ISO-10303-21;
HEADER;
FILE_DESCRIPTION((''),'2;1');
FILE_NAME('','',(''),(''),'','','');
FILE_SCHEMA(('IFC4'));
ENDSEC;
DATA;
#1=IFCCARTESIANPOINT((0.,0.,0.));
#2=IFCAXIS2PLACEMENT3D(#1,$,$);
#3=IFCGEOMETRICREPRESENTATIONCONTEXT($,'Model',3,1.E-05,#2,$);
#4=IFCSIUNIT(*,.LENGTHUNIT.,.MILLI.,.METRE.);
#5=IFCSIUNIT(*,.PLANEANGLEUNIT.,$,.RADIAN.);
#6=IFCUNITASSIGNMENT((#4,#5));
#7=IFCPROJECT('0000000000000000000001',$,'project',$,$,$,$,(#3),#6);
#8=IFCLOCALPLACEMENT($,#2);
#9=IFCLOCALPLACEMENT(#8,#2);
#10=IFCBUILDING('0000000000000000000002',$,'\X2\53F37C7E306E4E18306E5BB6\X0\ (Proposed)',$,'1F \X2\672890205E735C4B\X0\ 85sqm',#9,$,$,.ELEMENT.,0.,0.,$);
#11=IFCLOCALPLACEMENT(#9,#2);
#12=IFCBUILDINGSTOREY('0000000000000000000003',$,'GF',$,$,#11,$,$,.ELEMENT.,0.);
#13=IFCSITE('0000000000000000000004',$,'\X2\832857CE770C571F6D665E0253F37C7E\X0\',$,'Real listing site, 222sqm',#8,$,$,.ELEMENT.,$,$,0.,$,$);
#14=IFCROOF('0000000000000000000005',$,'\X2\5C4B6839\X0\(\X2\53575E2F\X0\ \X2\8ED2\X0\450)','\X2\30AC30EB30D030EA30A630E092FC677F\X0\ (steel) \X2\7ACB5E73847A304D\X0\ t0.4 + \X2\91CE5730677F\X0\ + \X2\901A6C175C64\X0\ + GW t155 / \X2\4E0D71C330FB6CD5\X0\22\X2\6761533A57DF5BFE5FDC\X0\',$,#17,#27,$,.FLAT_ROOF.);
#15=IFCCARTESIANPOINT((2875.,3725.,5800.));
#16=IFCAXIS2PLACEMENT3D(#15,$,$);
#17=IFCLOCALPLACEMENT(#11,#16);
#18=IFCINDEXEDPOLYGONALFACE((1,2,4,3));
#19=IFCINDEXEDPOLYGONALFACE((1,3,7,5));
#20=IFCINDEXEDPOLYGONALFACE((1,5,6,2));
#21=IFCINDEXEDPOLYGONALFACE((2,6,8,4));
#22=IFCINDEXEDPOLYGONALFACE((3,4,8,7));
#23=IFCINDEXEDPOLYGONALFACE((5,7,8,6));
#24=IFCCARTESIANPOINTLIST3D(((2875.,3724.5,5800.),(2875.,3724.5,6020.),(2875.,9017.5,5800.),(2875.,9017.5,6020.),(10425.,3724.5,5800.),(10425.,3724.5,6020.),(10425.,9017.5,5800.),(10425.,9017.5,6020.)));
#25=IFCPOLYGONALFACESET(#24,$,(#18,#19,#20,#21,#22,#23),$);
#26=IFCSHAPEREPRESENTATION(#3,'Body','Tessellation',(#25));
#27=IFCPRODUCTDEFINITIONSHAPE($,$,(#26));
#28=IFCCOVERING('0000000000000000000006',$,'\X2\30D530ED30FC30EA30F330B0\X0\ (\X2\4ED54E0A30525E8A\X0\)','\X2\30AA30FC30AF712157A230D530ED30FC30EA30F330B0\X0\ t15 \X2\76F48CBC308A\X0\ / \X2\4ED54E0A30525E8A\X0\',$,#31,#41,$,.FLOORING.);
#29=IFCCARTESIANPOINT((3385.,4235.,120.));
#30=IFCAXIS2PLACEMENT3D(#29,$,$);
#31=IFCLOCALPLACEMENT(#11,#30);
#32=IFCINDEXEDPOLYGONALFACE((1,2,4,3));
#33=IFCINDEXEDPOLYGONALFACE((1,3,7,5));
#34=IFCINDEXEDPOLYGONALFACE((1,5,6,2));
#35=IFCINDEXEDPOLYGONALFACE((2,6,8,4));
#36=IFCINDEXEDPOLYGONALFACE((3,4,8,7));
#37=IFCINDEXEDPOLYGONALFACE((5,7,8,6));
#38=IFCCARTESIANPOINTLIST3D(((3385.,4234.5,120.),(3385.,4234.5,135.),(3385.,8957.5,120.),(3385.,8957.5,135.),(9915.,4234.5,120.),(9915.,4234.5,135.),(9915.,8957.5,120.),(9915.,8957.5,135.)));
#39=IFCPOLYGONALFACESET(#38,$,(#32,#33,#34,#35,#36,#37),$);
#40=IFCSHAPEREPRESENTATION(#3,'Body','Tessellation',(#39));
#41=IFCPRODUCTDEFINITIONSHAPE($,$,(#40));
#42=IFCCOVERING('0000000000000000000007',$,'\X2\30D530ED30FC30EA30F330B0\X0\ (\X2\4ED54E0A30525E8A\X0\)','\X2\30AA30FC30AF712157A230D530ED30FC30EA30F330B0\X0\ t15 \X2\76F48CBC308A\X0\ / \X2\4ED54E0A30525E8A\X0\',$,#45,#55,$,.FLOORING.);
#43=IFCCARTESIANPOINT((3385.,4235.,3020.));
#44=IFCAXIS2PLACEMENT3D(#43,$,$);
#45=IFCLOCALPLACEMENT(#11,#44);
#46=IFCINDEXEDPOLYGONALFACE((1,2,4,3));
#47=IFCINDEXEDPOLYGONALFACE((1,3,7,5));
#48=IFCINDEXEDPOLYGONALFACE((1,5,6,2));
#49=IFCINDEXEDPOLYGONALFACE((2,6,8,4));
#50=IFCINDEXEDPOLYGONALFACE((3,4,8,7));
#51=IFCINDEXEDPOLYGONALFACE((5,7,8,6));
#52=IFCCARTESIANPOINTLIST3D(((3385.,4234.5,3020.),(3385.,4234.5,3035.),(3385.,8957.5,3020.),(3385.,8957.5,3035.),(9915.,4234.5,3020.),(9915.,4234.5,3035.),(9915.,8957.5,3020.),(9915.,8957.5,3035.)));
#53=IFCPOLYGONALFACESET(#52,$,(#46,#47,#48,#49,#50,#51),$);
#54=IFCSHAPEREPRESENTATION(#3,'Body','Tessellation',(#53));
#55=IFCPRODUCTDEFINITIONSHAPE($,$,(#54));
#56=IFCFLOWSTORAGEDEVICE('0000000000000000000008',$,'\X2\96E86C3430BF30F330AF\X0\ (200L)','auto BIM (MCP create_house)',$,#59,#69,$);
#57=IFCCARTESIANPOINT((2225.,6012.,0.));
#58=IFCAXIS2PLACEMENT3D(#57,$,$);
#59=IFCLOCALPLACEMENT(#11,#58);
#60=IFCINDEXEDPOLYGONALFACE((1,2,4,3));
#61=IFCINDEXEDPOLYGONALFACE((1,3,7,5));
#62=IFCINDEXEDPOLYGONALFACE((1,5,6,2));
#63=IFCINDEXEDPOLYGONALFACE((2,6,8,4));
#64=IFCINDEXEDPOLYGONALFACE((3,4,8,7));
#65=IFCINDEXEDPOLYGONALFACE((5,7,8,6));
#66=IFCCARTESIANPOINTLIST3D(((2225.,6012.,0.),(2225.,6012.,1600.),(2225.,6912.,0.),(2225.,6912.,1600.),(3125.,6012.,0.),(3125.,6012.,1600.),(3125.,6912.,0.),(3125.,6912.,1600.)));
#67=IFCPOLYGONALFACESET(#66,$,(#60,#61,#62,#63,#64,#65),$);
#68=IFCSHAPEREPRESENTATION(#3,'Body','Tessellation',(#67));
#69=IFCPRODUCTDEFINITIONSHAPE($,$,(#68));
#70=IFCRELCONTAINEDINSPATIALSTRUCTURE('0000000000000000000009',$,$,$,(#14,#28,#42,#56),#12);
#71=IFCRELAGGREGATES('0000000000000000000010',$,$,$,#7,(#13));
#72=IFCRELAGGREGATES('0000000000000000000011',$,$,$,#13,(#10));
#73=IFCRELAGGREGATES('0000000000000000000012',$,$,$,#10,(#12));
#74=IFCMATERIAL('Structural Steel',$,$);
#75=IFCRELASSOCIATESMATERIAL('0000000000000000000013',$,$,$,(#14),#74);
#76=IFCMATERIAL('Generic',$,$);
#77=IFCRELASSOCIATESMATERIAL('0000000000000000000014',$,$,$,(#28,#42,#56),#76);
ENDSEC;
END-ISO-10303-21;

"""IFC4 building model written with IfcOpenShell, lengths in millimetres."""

from ifc_helpers import new_model, si_unit, frame, frame_2d, origin, place, context, project, spatial, rectangle, extrude, material, element, save


model = new_model("IFC4")

# Units and contexts
model_context = context("Model", 3, precision=1e-05, world=origin())
ifc_project = project(units=[si_unit("LENGTHUNIT", "METRE", prefix="MILLI"), si_unit("PLANEANGLEUNIT", "RADIAN")], contexts=[model_context])

# Site, building, storey
site_placement = place(None, origin())
site = spatial("IfcSite", under=ifc_project, at=site_placement, Name="茨城県土浦市右籾", ObjectType="Real listing site, 222sqm", CompositionType="ELEMENT", RefElevation=0.0)
building_placement = place(site_placement, origin())
building = spatial("IfcBuilding", under=site, at=building_placement, Name="右籾の丘の家 (Proposed)", ObjectType="1F 木造平屋 85sqm", CompositionType="ELEMENT", ElevationOfRefHeight=0.0, ElevationOfTerrain=0.0)
storey_placement = place(building_placement, origin())
storey = spatial("IfcBuildingStorey", under=building, at=storey_placement, Name="GF", CompositionType="ELEMENT", Elevation=0.0)

# Shared definitions
ifc_material_1 = material(Name="Generic")

# Roof
ifc_material_2 = material(Name="Structural Steel")
for number, where, name in (
    (1, (2875.0, 3725.0, 5800.0), "屋根(南帯 軒450)"),
):
    element("IfcRoof", number, at=place(storey_placement, frame(where)), inside=storey, material=ifc_material_2, Name=name, Description="ガルバリウム鋼板 (steel) 立平葺き t0.4 + 野地板 + 通気層 + GW t155 / 不燃・法22条区域対応", PredefinedType="FLAT_ROOF", context=model_context, shape_type="SweptSolid", body=[
        extrude(rectangle(XDim=7550.0, YDim=5293.0, at=frame_2d((3775.0, 2646.0))), frame((2875.0, 3725.0, 5800.0)), (0.0, 0.0, 1.0), 220.0),
    ])

# Coverings
covering_1_placement = place(storey_placement, frame((3385.0, 4235.0, 120.0)))
element("IfcCovering", 2, at=covering_1_placement, inside=storey, material=ifc_material_1, Name="フローリング (仕上げ床)", Description="オーク無垢フローリング t15 直貼り / 仕上げ床", PredefinedType="FLOORING", context=model_context, shape_type="SweptSolid", body=[
    extrude(rectangle(XDim=6530.0, YDim=4723.0, at=frame_2d((3265.0, 2361.0))), frame((3385.0, 4235.0, 120.0)), (0.0, 0.0, 1.0), 15.0),
])
covering_2_placement = place(storey_placement, frame((3385.0, 4235.0, 3020.0)))
element("IfcCovering", 3, at=covering_2_placement, inside=storey, material=ifc_material_1, Name="フローリング (仕上げ床)", Description="オーク無垢フローリング t15 直貼り / 仕上げ床", PredefinedType="FLOORING", context=model_context, shape_type="SweptSolid", body=[
    extrude(rectangle(XDim=6530.0, YDim=4723.0, at=frame_2d((3265.0, 2361.0))), frame((3385.0, 4235.0, 3020.0)), (0.0, 0.0, 1.0), 15.0),
])

# Flow storage device
flow_storage_device_placement = place(storey_placement, frame((2225.0, 6012.0, 0.0)))
element("IfcFlowStorageDevice", 4, at=flow_storage_device_placement, inside=storey, material=ifc_material_1, Name="雨水タンク (200L)", Description="auto BIM (MCP create_house)", context=model_context, shape_type="SweptSolid", body=[
    extrude(rectangle(XDim=900.0, YDim=900.0, at=frame_2d((450.0, 450.0))), frame((2225.0, 6012.0, 0.0)), (0.0, 0.0, 1.0), 1600.0),
])

save(model, "model.ifc")
